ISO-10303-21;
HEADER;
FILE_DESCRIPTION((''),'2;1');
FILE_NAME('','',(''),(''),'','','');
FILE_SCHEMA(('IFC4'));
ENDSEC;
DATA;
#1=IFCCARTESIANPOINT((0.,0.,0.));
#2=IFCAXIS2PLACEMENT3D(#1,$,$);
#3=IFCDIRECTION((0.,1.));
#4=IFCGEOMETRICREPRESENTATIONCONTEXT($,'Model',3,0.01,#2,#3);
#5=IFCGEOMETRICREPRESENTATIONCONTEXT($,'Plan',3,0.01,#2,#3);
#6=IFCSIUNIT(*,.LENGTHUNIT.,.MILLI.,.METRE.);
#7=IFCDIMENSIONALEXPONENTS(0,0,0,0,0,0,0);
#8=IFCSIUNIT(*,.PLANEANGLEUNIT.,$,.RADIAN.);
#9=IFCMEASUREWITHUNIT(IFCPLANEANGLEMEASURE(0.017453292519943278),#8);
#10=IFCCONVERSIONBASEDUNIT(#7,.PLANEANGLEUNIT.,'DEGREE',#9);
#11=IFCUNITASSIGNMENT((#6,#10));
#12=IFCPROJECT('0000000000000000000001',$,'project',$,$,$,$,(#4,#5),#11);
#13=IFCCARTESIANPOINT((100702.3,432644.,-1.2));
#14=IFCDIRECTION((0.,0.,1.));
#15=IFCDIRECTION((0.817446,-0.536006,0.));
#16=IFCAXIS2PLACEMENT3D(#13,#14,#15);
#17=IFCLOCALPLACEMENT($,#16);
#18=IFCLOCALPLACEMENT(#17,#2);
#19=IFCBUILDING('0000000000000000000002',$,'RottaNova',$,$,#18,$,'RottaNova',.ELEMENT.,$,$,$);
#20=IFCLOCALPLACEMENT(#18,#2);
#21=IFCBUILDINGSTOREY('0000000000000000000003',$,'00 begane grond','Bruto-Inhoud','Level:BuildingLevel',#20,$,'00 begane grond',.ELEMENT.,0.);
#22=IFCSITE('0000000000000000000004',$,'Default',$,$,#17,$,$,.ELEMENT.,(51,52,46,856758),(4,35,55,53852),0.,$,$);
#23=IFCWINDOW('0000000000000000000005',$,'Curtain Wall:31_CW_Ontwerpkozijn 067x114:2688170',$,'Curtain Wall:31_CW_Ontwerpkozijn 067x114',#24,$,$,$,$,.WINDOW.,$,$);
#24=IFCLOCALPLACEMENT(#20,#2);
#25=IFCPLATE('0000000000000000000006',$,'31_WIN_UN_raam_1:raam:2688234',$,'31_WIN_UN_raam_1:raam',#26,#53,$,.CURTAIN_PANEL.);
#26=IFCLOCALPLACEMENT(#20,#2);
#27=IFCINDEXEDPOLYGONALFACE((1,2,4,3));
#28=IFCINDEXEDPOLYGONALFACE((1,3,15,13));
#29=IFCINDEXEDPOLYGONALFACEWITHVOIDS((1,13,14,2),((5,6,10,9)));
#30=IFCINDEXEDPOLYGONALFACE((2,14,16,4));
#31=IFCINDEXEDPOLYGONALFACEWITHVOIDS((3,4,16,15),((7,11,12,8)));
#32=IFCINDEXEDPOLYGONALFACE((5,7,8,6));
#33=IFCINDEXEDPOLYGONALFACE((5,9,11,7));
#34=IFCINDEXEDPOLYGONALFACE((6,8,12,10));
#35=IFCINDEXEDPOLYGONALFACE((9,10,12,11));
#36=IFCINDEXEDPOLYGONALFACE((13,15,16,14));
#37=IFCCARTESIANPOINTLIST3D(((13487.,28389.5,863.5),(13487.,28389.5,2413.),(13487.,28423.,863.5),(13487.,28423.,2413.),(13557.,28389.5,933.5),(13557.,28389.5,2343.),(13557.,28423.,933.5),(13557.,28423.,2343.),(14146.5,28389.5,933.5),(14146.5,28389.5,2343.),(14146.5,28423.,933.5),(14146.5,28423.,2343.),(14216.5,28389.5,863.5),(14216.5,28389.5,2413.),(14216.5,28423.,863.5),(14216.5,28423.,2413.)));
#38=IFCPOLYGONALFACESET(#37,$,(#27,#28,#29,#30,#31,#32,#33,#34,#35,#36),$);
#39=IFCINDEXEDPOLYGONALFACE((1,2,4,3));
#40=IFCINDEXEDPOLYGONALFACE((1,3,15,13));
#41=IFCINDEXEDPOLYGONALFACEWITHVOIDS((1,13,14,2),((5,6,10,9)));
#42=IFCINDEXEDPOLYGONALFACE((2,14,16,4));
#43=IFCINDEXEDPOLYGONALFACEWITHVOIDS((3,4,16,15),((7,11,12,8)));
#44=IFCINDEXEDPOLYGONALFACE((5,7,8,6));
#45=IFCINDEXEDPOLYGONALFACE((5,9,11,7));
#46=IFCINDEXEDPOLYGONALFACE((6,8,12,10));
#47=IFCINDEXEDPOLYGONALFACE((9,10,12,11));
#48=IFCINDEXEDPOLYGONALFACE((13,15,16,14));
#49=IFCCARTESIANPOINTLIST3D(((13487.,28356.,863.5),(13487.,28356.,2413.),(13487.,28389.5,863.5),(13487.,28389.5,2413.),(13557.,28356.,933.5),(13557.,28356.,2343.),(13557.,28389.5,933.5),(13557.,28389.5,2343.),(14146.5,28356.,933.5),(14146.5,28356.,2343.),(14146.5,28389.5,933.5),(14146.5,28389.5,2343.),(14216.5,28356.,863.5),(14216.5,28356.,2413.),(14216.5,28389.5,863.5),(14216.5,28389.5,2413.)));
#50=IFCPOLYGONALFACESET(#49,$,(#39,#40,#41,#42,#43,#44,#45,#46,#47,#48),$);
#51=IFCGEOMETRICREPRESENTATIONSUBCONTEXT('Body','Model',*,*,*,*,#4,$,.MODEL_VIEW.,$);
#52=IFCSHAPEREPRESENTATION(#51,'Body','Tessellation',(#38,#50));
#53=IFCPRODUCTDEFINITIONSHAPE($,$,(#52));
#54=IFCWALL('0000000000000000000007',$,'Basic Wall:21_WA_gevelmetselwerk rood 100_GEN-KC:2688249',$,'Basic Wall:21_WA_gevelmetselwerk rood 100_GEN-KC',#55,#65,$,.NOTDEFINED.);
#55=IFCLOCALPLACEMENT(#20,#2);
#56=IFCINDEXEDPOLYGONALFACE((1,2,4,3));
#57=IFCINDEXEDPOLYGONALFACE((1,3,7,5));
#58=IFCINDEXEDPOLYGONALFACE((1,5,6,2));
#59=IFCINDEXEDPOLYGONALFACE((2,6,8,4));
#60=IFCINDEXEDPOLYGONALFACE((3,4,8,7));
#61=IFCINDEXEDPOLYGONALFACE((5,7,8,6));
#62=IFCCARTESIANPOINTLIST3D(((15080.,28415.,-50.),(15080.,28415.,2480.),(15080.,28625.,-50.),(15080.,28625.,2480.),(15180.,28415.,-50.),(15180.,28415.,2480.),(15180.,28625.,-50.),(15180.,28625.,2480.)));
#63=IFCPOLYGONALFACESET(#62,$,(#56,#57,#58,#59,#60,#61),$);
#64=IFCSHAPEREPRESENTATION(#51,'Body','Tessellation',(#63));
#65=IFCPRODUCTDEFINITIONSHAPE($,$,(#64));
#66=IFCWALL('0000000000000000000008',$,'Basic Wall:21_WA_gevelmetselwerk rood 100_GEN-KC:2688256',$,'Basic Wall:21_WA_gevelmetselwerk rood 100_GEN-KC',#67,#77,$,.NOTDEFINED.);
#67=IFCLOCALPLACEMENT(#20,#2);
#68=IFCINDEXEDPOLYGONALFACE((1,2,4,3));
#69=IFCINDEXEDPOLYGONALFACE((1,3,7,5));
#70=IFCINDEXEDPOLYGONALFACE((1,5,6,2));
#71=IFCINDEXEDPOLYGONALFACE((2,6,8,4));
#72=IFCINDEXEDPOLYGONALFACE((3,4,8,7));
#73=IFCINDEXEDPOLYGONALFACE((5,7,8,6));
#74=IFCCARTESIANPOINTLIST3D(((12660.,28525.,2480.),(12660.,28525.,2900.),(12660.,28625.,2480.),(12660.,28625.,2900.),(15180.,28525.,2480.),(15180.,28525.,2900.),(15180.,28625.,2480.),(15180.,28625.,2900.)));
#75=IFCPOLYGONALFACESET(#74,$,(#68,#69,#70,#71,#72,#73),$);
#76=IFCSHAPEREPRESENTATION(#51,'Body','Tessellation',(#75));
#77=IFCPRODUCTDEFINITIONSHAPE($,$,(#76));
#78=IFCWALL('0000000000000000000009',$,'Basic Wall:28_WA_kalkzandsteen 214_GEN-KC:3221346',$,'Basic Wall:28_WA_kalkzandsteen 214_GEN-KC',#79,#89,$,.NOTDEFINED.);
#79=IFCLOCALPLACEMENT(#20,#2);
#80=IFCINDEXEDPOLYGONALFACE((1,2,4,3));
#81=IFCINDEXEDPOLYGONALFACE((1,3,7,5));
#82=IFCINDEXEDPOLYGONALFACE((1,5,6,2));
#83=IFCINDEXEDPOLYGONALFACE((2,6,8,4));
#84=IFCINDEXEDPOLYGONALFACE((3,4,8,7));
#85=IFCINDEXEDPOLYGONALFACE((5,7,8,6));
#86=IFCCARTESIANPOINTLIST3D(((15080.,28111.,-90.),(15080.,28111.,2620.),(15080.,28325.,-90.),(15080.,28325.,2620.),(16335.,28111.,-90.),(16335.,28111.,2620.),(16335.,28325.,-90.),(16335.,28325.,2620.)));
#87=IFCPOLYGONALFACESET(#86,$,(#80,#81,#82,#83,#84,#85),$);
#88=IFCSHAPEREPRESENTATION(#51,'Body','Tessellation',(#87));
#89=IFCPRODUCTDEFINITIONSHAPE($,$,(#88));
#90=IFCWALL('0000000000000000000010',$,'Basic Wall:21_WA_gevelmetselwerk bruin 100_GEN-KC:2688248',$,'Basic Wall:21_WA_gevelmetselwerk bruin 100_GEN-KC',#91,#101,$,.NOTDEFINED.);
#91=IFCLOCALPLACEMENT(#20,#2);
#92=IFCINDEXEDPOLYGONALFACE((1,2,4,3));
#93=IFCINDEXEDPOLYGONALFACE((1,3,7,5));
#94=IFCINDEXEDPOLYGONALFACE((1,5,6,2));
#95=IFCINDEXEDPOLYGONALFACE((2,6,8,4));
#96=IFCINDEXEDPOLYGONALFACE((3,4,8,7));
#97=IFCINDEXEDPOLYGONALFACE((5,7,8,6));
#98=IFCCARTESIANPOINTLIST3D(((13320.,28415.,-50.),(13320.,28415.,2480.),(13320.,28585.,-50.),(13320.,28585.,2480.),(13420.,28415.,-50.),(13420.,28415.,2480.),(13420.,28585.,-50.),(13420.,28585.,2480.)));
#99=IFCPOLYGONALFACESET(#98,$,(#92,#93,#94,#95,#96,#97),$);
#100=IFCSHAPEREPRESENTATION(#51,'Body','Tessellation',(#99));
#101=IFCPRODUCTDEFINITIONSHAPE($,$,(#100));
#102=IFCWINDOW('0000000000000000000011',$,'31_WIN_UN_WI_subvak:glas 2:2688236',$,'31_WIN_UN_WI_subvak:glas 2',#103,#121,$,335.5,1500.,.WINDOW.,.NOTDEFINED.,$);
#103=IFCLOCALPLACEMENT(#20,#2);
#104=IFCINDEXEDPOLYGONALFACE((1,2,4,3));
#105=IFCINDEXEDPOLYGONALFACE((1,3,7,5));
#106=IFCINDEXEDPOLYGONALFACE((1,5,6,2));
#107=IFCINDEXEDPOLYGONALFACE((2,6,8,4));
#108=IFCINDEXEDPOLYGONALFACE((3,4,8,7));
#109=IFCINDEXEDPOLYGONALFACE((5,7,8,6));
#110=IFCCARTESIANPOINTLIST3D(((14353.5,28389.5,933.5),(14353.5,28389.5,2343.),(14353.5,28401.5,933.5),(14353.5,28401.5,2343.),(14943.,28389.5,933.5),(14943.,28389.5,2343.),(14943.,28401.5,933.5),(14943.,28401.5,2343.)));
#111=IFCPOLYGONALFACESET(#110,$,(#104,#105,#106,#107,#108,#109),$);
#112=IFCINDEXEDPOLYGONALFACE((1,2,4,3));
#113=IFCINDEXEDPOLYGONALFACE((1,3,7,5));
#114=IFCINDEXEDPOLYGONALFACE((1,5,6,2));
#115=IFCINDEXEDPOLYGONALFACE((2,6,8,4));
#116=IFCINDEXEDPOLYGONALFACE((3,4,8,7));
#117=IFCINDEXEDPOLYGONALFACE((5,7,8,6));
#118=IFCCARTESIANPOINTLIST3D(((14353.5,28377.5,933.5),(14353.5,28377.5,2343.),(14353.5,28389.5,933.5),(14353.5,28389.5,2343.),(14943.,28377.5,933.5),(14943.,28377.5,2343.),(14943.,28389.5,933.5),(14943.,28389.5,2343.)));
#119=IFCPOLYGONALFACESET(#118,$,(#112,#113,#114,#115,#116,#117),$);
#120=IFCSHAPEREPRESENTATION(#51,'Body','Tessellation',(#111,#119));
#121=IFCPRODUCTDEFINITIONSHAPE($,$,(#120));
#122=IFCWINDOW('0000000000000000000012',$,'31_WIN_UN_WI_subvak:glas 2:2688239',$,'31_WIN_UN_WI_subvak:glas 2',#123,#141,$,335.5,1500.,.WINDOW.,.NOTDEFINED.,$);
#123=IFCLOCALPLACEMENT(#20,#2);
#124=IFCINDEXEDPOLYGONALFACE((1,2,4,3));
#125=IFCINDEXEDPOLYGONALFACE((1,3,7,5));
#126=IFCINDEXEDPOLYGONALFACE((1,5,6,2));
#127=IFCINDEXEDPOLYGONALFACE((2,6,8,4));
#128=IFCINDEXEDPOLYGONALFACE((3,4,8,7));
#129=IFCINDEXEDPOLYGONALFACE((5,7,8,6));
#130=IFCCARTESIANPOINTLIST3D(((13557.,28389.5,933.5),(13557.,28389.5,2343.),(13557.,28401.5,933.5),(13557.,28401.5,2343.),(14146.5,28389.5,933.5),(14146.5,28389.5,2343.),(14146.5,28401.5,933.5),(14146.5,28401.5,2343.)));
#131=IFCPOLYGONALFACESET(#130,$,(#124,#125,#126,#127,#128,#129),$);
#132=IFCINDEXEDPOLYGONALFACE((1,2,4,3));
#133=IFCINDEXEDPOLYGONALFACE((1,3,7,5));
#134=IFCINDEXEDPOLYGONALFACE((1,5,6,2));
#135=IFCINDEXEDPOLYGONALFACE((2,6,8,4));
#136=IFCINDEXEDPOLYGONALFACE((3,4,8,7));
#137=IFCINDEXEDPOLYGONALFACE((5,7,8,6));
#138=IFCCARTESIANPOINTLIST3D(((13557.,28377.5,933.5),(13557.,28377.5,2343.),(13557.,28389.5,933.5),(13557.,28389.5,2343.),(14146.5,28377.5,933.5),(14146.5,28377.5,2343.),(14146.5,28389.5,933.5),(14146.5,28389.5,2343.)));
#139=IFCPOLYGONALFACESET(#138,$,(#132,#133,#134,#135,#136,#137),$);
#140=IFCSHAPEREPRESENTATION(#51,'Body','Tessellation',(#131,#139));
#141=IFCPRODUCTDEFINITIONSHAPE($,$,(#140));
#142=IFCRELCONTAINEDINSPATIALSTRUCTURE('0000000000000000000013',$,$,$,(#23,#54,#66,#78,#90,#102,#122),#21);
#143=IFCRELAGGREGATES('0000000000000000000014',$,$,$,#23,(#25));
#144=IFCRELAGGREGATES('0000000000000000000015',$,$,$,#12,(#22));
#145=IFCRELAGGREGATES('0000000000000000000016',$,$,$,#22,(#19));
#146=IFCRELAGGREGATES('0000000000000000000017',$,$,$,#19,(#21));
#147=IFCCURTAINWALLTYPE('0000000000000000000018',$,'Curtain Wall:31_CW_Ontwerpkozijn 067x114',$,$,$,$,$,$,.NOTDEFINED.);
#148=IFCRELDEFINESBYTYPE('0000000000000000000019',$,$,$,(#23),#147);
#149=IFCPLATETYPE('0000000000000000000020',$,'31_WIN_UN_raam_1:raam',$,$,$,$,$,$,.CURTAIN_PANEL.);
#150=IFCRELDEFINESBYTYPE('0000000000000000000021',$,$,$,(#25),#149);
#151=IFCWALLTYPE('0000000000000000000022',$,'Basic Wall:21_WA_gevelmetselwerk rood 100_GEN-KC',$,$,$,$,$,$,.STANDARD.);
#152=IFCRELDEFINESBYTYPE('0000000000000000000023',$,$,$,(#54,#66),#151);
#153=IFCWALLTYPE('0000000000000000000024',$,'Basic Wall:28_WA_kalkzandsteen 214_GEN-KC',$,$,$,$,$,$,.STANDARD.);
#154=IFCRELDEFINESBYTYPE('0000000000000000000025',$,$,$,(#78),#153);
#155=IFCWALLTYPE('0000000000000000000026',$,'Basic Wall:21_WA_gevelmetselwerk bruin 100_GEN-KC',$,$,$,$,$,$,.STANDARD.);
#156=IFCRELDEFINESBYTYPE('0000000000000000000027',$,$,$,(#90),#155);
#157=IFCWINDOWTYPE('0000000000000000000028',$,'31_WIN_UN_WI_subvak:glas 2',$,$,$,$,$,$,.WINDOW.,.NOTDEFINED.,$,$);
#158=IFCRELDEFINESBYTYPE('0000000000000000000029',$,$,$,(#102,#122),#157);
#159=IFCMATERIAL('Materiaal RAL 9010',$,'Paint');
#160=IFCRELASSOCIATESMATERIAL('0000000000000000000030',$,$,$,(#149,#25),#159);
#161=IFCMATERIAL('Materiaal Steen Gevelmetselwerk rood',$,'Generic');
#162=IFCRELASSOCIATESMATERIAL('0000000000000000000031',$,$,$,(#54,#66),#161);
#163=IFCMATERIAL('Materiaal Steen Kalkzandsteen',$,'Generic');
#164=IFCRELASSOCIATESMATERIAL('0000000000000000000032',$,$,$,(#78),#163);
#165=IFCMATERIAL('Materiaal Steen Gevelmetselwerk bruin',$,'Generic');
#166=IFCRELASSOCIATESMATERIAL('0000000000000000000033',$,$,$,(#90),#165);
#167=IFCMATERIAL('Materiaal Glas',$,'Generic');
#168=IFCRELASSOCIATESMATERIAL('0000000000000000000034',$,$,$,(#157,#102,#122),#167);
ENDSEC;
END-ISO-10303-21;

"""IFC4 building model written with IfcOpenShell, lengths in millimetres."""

from ifc_helpers import new_model, entity, si_unit, converted_unit, direction, frame, origin, place, context, subcontext, project, spatial, indexed_curve, outline, extrude, source, transform, mapped, material, type_object, type_shapes, element, aggregate, save


model = new_model("IFC4")

# Units and contexts
model_context = context("Model", 3, precision=0.01, world=origin(), true_north=direction((0.0, 1.0)))
plan_context = context("Plan", 3, precision=0.01, world=origin(), true_north=direction((0.0, 1.0)))
body_context = subcontext(model_context, "Body", "Model", "MODEL_VIEW")
ifc_project = project(units=[si_unit("LENGTHUNIT", "METRE", prefix="MILLI"), converted_unit("PLANEANGLEUNIT", "DEGREE", entity("IfcPlaneAngleMeasure", 0.017453292519943278), si_unit("PLANEANGLEUNIT", "RADIAN"), dimensions=[0, 0, 0, 0, 0, 0, 0])], contexts=[model_context, plan_context])

# Site, building, storey
site_placement = place(None, frame((100702.3, 432644.0, -1.2), z_axis=(0.0, 0.0, 1.0), x_axis=(0.817446, -0.536006, 0.0)))
site = spatial("IfcSite", under=ifc_project, at=site_placement, Name="Default", CompositionType="ELEMENT", RefLatitude=(51, 52, 46, 856758), RefLongitude=(4, 35, 55, 53852), RefElevation=0.0)
building_placement = place(site_placement, origin())
building = spatial("IfcBuilding", under=site, at=building_placement, Name="RottaNova", LongName="RottaNova", CompositionType="ELEMENT")
storey_placement = place(building_placement, origin())
storey = spatial("IfcBuildingStorey", under=building, at=storey_placement, Name="00 begane grond", Description="Bruto-Inhoud", ObjectType="Level:BuildingLevel", LongName="00 begane grond", CompositionType="ELEMENT", Elevation=0.0)

# Shared definitions
curtain_wall_type = type_object("IfcCurtainWallType", Name="Curtain Wall:31_CW_Ontwerpkozijn 067x114", PredefinedType="NOTDEFINED")

# Window
window_1_placement = place(storey_placement, origin())
window_1 = element("IfcWindow", 1, at=window_1_placement, inside=storey, type_object=curtain_wall_type, Name="Curtain Wall:31_CW_Ontwerpkozijn 067x114:2688170", ObjectType="Curtain Wall:31_CW_Ontwerpkozijn 067x114", PredefinedType="WINDOW")

# Plate
ifc_material_1 = material(Name="Materiaal Glas", Category="Generic")
ifc_material_2 = material(Name="Materiaal RAL 9010", Category="Paint")
plate_type_1 = type_object("IfcPlateType", Name="31_WIN_UN_raam_1:raam", PredefinedType="CURTAIN_PANEL", material=ifc_material_2)
shared_shape_1 = source(origin(), body_context, "Body", "SweptSolid", [
    extrude(outline(indexed_curve([(-364.7, -774.7), (364.7, -774.7), (364.7, 774.7), (-364.7, 774.7), (-364.7, -774.7)], self_intersect=False), holes=[indexed_curve([(-294.7, 704.7), (294.7, 704.7), (294.7, -704.8), (-294.7, -704.8), (-294.7, 704.7)], self_intersect=False)]), frame((0.0, -92.0, 774.8), z_axis=(0.0, 1.0, 0.0), x_axis=(1.0, 0.0, 0.0)), (0.0, 0.0, 1.0), 33.5),
    extrude(outline(indexed_curve([(-364.7, -774.7), (364.7, -774.7), (364.7, 774.7), (-364.7, 774.7), (-364.7, -774.7)], self_intersect=False), holes=[indexed_curve([(-294.7, 704.7), (294.7, 704.7), (294.7, -704.8), (-294.7, -704.8), (-294.7, 704.7)], self_intersect=False)]), frame((0.0, -58.5, 774.8), z_axis=(0.0, 1.0, 0.0), x_axis=(1.0, 0.0, 0.0)), (0.0, 0.0, 1.0), 33.5),
])
type_shapes(plate_type_1, [shared_shape_1])
plate_1_placement = place(window_1_placement, frame((13851.8, 28331.0, 863.5), z_axis=(0.0, 0.0, 1.0), x_axis=(-1.0, 0.0, 0.0)))
plate_1 = element("IfcPlate", 2, at=plate_1_placement, type_object=plate_type_1, material=ifc_material_2, Name="31_WIN_UN_raam_1:raam:2688234", ObjectType="31_WIN_UN_raam_1:raam", PredefinedType="CURTAIN_PANEL", context=body_context, shape_type="MappedRepresentation", body=[
    mapped(shared_shape_1, transform((0.0, 0.0, 0.0), scale=1.0)),
])
aggregate(window_1, [plate_1])

# Walls
ifc_material_3 = material(Name="Materiaal Steen Gevelmetselwerk rood", Category="Generic")
wall_type_1 = type_object("IfcWallType", Name="Basic Wall:21_WA_gevelmetselwerk rood 100_GEN-KC", PredefinedType="STANDARD")
wall_1_placement = place(storey_placement, frame((15130.0, 28415.0, -50.0), z_axis=(0.0, 0.0, 1.0), x_axis=(0.0, 1.0, 0.0)))
element("IfcWall", 3, at=wall_1_placement, inside=storey, type_object=wall_type_1, material=ifc_material_3, Name="Basic Wall:21_WA_gevelmetselwerk rood 100_GEN-KC:2688249", ObjectType="Basic Wall:21_WA_gevelmetselwerk rood 100_GEN-KC", PredefinedType="NOTDEFINED", context=body_context, shape_type="SweptSolid", body=[
    extrude(outline(indexed_curve([(210.0, 50.0), (0.0, 50.0), (0.0, -50.0), (210.0, -50.0), (210.0, 50.0)], self_intersect=False)), origin(), (0.0, 0.0, 1.0), 2530.0),
])
wall_2_placement = place(storey_placement, frame((15180.0, 28575.0, 2480.0), z_axis=(0.0, 0.0, 1.0), x_axis=(-1.0, 0.0, 0.0)))
element("IfcWall", 4, at=wall_2_placement, inside=storey, type_object=wall_type_1, material=ifc_material_3, Name="Basic Wall:21_WA_gevelmetselwerk rood 100_GEN-KC:2688256", ObjectType="Basic Wall:21_WA_gevelmetselwerk rood 100_GEN-KC", PredefinedType="NOTDEFINED", context=body_context, shape_type="SweptSolid", body=[
    extrude(outline(indexed_curve([(2520.0, 50.0), (0.0, 50.0), (0.0, -50.0), (2520.0, -50.0), (2520.0, 50.0)], self_intersect=False)), origin(), (0.0, 0.0, 1.0), 420.0),
])
ifc_material_4 = material(Name="Materiaal Steen Kalkzandsteen", Category="Generic")
wall_type_2 = type_object("IfcWallType", Name="Basic Wall:28_WA_kalkzandsteen 214_GEN-KC", PredefinedType="STANDARD")
wall_3_placement = place(storey_placement, frame((15080.0, 28218.0, -90.0)))
element("IfcWall", 5, at=wall_3_placement, inside=storey, type_object=wall_type_2, material=ifc_material_4, Name="Basic Wall:28_WA_kalkzandsteen 214_GEN-KC:3221346", ObjectType="Basic Wall:28_WA_kalkzandsteen 214_GEN-KC", PredefinedType="NOTDEFINED", context=body_context, shape_type="SweptSolid", body=[
    extrude(outline(indexed_curve([(1255.0, 107.0), (0.0, 107.0), (0.0, -107.0), (1255.0, -107.0), (1255.0, 107.0)], self_intersect=False)), origin(), (0.0, 0.0, 1.0), 2710.0),
])
ifc_material_5 = material(Name="Materiaal Steen Gevelmetselwerk bruin", Category="Generic")
wall_type_3 = type_object("IfcWallType", Name="Basic Wall:21_WA_gevelmetselwerk bruin 100_GEN-KC", PredefinedType="STANDARD")
wall_4_placement = place(storey_placement, frame((13370.0, 28415.0, -50.0), z_axis=(0.0, 0.0, 1.0), x_axis=(0.0, 1.0, 0.0)))
element("IfcWall", 6, at=wall_4_placement, inside=storey, type_object=wall_type_3, material=ifc_material_5, Name="Basic Wall:21_WA_gevelmetselwerk bruin 100_GEN-KC:2688248", ObjectType="Basic Wall:21_WA_gevelmetselwerk bruin 100_GEN-KC", PredefinedType="NOTDEFINED", context=body_context, shape_type="SweptSolid", body=[
    extrude(outline(indexed_curve([(170.0, 50.0), (0.0, 50.0), (0.0, -50.0), (170.0, -50.0), (170.0, 50.0)], self_intersect=False)), origin(), (0.0, 0.0, 1.0), 2530.0),
])

# Windows
window_type = type_object("IfcWindowType", Name="31_WIN_UN_WI_subvak:glas 2", PartitioningType="NOTDEFINED", PredefinedType="WINDOW", material=ifc_material_1)
shared_shape_2 = source(origin(), body_context, "Body", "SweptSolid", [
    extrude(outline(indexed_curve([(-294.7, -6.0), (294.7, -6.0), (294.7, 6.0), (-294.7, 6.0), (-294.7, -6.0)], self_intersect=False)), frame((0.0, -6.0, 0.0)), (0.0, 0.0, 1.0), 1409.5),
    extrude(outline(indexed_curve([(-294.8, -6.0), (294.8, -6.0), (294.8, 6.0), (-294.8, 6.0), (-294.8, -6.0)], self_intersect=False)), frame((0.0, 6.0, 0.0)), (0.0, 0.0, 1.0), 1409.5),
])
type_shapes(window_type, [shared_shape_2])
for number, where, z_axis, x_axis, name in (
    (7, (14648.3, 28389.5, 933.5), (0.0, 0.0, 1.0), (-1.0, 0.0, 0.0), "31_WIN_UN_WI_subvak:glas 2:2688236"),
    (8, (13851.8, 28389.5, 933.5), (0.0, 0.0, 1.0), (-1.0, 0.0, 0.0), "31_WIN_UN_WI_subvak:glas 2:2688239"),
):
    element("IfcWindow", number, at=place(storey_placement, frame(where, z_axis=z_axis, x_axis=x_axis)), inside=storey, type_object=window_type, material=ifc_material_1, Name=name, ObjectType="31_WIN_UN_WI_subvak:glas 2", OverallHeight=335.5, OverallWidth=1500.0, PartitioningType="NOTDEFINED", PredefinedType="WINDOW", context=body_context, shape_type="MappedRepresentation", body=[
        mapped(shared_shape_2, transform((0.0, 0.0, 0.0), scale=1.0)),
    ])

save(model, "model.ifc")
